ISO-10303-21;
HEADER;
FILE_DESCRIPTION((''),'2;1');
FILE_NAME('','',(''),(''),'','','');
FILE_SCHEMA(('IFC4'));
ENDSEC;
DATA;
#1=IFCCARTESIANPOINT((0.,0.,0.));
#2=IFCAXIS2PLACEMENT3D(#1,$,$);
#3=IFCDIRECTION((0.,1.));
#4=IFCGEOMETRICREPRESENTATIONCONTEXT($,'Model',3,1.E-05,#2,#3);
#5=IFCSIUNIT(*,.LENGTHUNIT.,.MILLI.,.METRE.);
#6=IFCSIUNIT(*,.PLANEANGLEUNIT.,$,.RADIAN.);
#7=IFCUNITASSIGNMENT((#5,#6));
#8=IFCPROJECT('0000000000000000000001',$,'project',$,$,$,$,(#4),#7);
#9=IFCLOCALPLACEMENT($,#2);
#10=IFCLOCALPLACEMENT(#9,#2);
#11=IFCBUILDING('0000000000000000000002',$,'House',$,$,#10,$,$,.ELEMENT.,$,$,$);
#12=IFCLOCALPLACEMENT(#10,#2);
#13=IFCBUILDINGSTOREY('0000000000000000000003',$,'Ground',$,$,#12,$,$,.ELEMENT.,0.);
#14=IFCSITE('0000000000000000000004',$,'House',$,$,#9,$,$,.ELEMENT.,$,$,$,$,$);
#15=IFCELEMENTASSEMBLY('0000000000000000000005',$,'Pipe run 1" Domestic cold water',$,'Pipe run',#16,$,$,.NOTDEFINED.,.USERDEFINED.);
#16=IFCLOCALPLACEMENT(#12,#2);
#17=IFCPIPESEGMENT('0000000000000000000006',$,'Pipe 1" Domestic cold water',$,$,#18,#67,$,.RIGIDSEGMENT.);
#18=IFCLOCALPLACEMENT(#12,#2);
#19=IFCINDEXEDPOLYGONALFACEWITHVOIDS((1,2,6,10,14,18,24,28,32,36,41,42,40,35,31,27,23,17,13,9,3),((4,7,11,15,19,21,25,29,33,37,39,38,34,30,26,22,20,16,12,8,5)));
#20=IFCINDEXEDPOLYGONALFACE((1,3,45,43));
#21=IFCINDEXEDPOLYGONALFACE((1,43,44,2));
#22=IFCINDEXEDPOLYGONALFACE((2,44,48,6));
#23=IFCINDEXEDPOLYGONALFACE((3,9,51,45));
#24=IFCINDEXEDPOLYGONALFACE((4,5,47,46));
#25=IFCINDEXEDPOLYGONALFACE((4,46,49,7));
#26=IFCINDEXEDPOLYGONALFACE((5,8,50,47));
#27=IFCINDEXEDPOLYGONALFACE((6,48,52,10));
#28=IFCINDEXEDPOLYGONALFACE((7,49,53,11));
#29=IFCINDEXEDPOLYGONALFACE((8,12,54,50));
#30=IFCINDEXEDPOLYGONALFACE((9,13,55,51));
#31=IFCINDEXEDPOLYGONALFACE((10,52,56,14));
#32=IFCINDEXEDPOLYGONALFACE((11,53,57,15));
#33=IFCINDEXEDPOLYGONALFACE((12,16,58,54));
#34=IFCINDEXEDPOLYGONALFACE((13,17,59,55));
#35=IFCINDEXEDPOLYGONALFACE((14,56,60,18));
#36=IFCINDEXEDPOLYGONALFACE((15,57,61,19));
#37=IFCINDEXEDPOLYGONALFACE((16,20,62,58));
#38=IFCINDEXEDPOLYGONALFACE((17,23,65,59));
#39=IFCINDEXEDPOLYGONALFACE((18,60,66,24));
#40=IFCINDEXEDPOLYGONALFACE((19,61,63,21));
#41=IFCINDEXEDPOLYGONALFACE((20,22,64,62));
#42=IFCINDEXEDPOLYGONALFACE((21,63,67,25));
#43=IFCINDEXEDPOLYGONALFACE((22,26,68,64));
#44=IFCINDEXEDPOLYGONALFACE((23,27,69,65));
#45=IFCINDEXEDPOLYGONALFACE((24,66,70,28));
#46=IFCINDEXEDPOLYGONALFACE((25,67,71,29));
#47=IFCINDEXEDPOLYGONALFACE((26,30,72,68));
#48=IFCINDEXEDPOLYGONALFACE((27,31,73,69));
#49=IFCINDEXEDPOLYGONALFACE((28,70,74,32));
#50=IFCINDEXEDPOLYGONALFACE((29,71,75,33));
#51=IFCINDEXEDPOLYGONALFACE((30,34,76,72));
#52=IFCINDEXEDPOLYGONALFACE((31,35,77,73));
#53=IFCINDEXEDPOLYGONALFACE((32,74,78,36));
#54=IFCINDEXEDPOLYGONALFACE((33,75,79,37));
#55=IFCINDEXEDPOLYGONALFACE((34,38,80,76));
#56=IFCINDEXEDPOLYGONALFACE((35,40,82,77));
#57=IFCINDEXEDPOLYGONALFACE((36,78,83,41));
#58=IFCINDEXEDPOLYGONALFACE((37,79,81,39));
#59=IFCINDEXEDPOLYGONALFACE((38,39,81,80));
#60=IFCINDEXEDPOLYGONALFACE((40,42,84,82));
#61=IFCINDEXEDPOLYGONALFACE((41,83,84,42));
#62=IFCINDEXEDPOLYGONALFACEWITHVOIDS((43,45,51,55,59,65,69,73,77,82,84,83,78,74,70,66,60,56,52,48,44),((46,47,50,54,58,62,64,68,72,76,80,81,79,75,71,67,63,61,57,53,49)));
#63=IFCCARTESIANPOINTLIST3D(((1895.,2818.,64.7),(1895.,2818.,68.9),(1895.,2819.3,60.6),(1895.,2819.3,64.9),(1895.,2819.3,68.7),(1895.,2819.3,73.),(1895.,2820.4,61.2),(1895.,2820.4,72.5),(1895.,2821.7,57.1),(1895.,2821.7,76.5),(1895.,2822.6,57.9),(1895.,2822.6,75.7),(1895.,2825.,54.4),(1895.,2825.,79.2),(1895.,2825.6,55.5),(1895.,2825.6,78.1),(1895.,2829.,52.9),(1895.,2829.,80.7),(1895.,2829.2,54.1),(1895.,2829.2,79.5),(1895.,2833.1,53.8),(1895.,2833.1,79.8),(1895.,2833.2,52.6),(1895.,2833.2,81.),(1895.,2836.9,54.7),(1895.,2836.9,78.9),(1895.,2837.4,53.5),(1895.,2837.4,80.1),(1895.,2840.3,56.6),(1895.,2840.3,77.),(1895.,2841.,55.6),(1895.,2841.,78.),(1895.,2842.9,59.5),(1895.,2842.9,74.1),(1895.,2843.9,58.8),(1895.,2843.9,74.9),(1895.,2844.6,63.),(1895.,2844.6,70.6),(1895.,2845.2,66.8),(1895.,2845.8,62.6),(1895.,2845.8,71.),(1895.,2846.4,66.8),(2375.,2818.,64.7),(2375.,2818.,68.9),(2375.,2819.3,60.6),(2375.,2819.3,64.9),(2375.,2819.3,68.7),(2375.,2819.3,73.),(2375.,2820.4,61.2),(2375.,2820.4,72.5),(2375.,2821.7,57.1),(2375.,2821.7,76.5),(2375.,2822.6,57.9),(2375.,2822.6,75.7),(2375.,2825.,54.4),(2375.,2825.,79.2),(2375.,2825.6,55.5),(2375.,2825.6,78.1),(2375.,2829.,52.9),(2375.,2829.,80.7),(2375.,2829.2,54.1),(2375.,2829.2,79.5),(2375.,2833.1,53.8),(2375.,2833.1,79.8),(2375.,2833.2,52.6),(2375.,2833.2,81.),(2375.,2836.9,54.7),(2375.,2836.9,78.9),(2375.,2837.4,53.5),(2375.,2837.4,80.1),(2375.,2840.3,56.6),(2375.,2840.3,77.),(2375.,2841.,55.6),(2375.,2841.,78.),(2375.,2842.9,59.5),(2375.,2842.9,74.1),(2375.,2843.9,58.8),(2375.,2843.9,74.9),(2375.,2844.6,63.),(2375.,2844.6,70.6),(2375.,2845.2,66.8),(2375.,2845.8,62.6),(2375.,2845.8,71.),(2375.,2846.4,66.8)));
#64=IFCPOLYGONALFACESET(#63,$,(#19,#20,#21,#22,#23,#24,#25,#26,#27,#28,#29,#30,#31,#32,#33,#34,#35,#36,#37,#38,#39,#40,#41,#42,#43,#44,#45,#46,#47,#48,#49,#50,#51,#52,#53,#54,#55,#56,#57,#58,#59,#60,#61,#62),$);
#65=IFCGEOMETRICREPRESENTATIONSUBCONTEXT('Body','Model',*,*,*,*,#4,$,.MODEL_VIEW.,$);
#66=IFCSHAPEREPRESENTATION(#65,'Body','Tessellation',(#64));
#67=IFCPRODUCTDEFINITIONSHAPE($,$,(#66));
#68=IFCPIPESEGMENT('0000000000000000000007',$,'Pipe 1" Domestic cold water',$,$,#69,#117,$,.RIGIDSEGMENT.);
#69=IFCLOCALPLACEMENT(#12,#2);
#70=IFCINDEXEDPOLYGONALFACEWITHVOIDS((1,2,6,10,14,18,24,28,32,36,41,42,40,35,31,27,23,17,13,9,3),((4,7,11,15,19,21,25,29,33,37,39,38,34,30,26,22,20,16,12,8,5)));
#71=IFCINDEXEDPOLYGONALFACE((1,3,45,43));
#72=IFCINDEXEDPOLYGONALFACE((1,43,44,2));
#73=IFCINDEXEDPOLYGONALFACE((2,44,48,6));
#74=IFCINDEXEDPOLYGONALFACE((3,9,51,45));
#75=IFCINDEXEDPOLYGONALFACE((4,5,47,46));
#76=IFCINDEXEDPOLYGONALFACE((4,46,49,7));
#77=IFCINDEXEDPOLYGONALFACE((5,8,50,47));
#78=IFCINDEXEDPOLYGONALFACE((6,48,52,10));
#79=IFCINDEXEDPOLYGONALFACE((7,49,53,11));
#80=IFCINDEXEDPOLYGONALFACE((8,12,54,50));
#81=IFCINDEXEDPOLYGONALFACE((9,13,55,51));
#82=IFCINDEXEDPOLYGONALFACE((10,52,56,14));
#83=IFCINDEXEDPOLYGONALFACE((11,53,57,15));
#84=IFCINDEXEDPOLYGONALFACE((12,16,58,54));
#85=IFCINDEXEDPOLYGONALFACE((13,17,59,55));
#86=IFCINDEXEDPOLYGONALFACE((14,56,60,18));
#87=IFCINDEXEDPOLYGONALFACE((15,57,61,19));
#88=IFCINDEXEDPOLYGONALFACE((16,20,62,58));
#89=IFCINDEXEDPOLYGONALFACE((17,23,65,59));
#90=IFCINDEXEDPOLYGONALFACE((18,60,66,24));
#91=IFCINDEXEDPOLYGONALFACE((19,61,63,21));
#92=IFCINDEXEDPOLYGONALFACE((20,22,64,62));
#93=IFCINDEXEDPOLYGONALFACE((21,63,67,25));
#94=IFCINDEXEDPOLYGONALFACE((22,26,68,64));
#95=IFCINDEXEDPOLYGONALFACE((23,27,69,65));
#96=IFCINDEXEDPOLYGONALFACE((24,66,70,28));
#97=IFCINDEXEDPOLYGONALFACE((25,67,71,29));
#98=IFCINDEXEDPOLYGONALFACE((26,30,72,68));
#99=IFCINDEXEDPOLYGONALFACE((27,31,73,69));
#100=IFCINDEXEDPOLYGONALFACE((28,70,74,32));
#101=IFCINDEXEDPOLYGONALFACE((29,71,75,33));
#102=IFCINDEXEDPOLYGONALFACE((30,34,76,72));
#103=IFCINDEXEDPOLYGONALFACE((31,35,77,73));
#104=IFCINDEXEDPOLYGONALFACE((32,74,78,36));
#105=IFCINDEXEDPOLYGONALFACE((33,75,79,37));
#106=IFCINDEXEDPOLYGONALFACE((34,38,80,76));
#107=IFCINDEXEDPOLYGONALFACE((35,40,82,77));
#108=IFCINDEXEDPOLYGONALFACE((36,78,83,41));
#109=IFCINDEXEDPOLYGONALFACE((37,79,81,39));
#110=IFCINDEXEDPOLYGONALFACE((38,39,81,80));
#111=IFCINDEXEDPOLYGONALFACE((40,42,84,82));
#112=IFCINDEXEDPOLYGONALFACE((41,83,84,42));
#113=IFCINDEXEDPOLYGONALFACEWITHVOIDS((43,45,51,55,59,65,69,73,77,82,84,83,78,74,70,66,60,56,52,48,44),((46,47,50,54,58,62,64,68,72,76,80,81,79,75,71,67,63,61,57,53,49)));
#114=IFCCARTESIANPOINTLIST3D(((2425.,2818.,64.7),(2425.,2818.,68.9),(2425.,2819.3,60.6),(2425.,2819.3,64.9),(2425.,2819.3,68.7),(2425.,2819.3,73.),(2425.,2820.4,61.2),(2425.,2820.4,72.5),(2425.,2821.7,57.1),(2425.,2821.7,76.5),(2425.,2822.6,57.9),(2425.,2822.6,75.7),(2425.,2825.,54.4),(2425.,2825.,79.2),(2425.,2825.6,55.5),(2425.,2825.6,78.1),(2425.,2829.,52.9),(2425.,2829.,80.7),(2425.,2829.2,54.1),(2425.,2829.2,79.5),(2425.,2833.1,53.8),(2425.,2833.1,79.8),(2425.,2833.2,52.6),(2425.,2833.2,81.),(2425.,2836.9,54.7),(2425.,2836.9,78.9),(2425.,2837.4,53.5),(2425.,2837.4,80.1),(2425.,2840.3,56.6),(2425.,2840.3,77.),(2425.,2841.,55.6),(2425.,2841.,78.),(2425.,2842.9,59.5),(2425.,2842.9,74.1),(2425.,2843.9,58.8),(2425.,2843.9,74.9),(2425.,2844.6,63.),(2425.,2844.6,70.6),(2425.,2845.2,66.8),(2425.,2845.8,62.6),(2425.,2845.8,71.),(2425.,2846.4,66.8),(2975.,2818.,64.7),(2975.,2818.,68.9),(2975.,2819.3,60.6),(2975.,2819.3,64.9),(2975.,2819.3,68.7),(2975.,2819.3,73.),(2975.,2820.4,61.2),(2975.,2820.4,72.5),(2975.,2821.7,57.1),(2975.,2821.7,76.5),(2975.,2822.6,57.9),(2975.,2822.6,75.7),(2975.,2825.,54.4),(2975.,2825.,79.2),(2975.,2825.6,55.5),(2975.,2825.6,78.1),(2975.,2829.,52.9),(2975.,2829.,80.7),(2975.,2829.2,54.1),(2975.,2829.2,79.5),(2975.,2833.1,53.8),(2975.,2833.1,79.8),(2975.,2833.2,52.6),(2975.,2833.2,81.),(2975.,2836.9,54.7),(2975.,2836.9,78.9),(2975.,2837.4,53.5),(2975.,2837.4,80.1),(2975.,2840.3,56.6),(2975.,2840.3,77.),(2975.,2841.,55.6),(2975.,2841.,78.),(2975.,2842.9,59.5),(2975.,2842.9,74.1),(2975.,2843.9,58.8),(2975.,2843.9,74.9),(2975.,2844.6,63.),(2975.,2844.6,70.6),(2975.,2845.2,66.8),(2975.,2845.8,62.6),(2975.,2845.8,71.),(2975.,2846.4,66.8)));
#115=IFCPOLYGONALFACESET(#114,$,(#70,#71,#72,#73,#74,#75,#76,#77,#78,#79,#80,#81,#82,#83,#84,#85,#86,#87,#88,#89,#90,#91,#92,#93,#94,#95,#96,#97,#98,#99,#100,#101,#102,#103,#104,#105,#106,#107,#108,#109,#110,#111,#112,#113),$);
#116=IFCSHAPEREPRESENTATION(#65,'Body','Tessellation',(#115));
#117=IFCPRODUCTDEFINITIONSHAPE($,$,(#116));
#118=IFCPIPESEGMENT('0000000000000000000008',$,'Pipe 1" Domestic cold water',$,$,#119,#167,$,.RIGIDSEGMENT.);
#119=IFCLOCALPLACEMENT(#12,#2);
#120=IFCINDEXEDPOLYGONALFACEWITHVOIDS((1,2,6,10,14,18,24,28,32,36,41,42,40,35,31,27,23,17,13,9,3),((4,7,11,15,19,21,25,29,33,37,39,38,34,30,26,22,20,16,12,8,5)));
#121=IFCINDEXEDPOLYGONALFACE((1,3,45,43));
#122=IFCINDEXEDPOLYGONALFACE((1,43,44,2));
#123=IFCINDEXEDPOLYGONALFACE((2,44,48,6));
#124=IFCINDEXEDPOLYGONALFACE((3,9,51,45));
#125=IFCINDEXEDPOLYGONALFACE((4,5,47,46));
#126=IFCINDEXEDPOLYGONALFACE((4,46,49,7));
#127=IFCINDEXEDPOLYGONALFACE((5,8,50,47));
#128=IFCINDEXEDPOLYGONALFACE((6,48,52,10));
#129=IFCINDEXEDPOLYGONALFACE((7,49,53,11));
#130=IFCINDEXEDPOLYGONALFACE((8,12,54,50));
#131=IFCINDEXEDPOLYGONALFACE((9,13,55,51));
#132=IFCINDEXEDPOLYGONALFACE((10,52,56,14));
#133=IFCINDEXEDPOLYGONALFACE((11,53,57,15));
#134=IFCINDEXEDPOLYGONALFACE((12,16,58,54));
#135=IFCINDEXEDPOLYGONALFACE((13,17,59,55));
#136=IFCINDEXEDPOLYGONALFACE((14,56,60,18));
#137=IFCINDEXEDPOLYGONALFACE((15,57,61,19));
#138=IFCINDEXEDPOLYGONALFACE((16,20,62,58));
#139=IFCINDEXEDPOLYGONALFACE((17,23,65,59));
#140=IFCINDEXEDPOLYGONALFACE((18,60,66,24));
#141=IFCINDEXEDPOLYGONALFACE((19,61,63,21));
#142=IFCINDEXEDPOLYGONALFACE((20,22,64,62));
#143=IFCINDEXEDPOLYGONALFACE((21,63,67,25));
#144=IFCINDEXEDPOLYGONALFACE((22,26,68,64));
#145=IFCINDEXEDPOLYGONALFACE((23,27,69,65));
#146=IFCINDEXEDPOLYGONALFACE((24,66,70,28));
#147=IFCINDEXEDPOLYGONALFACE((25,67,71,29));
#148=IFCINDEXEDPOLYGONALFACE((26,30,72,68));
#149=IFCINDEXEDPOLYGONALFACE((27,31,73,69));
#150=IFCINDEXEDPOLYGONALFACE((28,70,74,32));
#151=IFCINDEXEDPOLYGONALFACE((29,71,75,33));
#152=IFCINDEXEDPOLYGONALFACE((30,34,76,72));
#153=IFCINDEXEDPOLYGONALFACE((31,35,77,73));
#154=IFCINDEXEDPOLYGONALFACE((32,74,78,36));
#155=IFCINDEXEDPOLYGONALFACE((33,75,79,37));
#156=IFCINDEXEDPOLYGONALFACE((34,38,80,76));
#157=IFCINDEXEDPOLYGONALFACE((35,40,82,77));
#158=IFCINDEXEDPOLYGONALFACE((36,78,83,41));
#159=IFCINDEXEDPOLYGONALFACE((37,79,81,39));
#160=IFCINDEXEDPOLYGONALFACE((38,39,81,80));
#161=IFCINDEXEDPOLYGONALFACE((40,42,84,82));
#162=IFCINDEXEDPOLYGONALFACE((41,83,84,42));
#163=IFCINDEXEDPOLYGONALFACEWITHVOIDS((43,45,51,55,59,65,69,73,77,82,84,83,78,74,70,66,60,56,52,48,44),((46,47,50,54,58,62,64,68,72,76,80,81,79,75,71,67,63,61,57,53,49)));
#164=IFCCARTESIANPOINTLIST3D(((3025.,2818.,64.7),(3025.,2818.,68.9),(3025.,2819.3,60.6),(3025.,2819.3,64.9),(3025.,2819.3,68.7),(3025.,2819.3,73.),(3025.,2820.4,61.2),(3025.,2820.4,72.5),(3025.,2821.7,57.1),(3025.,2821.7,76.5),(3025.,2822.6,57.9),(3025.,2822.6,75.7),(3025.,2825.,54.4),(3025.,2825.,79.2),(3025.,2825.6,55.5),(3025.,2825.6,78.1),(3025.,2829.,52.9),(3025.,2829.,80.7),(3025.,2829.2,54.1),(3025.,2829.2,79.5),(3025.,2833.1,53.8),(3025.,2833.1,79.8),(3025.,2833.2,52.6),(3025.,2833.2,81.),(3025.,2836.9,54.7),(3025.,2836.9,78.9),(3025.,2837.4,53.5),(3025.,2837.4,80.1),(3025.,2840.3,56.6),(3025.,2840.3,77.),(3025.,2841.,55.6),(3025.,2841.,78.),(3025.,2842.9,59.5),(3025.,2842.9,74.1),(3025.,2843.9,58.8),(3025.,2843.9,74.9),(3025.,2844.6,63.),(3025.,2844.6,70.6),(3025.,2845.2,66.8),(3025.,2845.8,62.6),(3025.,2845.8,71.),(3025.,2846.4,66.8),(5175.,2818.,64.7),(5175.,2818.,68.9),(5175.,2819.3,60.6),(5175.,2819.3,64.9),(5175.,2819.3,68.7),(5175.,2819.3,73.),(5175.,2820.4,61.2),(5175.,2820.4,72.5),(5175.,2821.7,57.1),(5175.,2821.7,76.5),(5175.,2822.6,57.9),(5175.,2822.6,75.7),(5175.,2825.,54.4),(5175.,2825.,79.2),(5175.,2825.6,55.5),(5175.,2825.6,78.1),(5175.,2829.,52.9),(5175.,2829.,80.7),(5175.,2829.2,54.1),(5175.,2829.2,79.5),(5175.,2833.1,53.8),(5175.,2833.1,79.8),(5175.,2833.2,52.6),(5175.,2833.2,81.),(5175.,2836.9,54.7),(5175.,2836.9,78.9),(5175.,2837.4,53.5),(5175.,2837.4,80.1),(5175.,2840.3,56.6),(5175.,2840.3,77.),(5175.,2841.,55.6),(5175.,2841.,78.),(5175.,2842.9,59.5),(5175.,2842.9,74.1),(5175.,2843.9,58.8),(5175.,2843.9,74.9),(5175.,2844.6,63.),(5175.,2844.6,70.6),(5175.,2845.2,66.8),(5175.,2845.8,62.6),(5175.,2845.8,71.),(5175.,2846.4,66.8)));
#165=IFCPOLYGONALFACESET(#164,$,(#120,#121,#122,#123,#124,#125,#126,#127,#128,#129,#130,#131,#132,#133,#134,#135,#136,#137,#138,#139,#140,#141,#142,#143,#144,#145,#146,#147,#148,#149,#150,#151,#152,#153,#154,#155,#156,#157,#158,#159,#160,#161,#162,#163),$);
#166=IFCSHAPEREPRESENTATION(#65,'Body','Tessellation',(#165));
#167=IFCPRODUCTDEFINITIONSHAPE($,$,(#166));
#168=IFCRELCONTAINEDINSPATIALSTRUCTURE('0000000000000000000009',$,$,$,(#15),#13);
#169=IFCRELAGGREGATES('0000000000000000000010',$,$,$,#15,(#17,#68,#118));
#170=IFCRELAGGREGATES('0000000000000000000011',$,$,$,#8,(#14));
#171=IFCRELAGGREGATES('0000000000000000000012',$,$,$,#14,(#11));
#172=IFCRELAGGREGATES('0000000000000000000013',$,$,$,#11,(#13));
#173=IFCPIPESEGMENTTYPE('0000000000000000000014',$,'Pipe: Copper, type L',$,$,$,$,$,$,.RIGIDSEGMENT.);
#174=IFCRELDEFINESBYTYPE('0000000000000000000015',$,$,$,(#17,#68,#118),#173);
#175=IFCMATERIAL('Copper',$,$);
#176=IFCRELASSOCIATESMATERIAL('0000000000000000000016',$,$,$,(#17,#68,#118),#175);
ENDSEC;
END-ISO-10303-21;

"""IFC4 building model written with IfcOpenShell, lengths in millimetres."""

from ifc_helpers import new_model, si_unit, direction, frame, origin, origin_with_axes, origin_2d, place, context, subcontext, project, spatial, hollow_circle, extrude, material, type_object, element, aggregate, save


model = new_model("IFC4")

# Units and contexts
model_context = context("Model", 3, precision=1e-05, world=origin(), true_north=direction((0.0, 1.0)))
body_context = subcontext(model_context, "Body", "Model", "MODEL_VIEW")
ifc_project = project(units=[si_unit("LENGTHUNIT", "METRE", prefix="MILLI"), si_unit("PLANEANGLEUNIT", "RADIAN")], contexts=[model_context])

# Site, building, storey
site_placement = place(None, origin())
site = spatial("IfcSite", under=ifc_project, at=site_placement, Name="House", CompositionType="ELEMENT")
building_placement = place(site_placement, origin())
building = spatial("IfcBuilding", under=site, at=building_placement, Name="House", CompositionType="ELEMENT")
storey_placement = place(building_placement, origin())
storey = spatial("IfcBuildingStorey", under=building, at=storey_placement, Name="Ground", CompositionType="ELEMENT", Elevation=0.0)

# Shared definitions
ifc_material = material(Name="Copper")
pipe_segment_type = type_object("IfcPipeSegmentType", Name="Pipe: Copper, type L", PredefinedType="RIGIDSEGMENT")

# Element assembly, pipe segments
assembly_1_placement = place(storey_placement, origin_with_axes())
assembly_1 = element("IfcElementAssembly", 1, at=assembly_1_placement, inside=storey, Name="Pipe run 1\" Domestic cold water", ObjectType="Pipe run", AssemblyPlace="NOTDEFINED", PredefinedType="USERDEFINED")
pipe_segment_1_placement = place(storey_placement, origin_with_axes())
pipe_segment_1 = element("IfcPipeSegment", 2, at=pipe_segment_1_placement, type_object=pipe_segment_type, material=ifc_material, Name="Pipe 1\" Domestic cold water", PredefinedType="RIGIDSEGMENT", context=body_context, shape_type="SweptSolid", body=[
    extrude(hollow_circle(Radius=14.3, WallThickness=1.3, at=origin_2d()), frame((1895.0, 2832.1, 66.8), z_axis=(1.0, 0.0, 0.0), x_axis=(0.0, 1.0, 0.0)), (0.0, 0.0, 1.0), 480.0),
])
pipe_segment_2_placement = place(storey_placement, origin_with_axes())
pipe_segment_2 = element("IfcPipeSegment", 3, at=pipe_segment_2_placement, type_object=pipe_segment_type, material=ifc_material, Name="Pipe 1\" Domestic cold water", PredefinedType="RIGIDSEGMENT", context=body_context, shape_type="SweptSolid", body=[
    extrude(hollow_circle(Radius=14.3, WallThickness=1.3, at=origin_2d()), frame((2425.0, 2832.1, 66.8), z_axis=(1.0, 0.0, 0.0), x_axis=(0.0, 1.0, 0.0)), (0.0, 0.0, 1.0), 550.0),
])
pipe_segment_3_placement = place(storey_placement, origin_with_axes())
pipe_segment_3 = element("IfcPipeSegment", 4, at=pipe_segment_3_placement, type_object=pipe_segment_type, material=ifc_material, Name="Pipe 1\" Domestic cold water", PredefinedType="RIGIDSEGMENT", context=body_context, shape_type="SweptSolid", body=[
    extrude(hollow_circle(Radius=14.3, WallThickness=1.3, at=origin_2d()), frame((3025.0, 2832.1, 66.8), z_axis=(1.0, 0.0, 0.0), x_axis=(0.0, 1.0, 0.0)), (0.0, 0.0, 1.0), 2150.0),
])

aggregate(assembly_1, [pipe_segment_1, pipe_segment_2, pipe_segment_3])

save(model, "model.ifc")
